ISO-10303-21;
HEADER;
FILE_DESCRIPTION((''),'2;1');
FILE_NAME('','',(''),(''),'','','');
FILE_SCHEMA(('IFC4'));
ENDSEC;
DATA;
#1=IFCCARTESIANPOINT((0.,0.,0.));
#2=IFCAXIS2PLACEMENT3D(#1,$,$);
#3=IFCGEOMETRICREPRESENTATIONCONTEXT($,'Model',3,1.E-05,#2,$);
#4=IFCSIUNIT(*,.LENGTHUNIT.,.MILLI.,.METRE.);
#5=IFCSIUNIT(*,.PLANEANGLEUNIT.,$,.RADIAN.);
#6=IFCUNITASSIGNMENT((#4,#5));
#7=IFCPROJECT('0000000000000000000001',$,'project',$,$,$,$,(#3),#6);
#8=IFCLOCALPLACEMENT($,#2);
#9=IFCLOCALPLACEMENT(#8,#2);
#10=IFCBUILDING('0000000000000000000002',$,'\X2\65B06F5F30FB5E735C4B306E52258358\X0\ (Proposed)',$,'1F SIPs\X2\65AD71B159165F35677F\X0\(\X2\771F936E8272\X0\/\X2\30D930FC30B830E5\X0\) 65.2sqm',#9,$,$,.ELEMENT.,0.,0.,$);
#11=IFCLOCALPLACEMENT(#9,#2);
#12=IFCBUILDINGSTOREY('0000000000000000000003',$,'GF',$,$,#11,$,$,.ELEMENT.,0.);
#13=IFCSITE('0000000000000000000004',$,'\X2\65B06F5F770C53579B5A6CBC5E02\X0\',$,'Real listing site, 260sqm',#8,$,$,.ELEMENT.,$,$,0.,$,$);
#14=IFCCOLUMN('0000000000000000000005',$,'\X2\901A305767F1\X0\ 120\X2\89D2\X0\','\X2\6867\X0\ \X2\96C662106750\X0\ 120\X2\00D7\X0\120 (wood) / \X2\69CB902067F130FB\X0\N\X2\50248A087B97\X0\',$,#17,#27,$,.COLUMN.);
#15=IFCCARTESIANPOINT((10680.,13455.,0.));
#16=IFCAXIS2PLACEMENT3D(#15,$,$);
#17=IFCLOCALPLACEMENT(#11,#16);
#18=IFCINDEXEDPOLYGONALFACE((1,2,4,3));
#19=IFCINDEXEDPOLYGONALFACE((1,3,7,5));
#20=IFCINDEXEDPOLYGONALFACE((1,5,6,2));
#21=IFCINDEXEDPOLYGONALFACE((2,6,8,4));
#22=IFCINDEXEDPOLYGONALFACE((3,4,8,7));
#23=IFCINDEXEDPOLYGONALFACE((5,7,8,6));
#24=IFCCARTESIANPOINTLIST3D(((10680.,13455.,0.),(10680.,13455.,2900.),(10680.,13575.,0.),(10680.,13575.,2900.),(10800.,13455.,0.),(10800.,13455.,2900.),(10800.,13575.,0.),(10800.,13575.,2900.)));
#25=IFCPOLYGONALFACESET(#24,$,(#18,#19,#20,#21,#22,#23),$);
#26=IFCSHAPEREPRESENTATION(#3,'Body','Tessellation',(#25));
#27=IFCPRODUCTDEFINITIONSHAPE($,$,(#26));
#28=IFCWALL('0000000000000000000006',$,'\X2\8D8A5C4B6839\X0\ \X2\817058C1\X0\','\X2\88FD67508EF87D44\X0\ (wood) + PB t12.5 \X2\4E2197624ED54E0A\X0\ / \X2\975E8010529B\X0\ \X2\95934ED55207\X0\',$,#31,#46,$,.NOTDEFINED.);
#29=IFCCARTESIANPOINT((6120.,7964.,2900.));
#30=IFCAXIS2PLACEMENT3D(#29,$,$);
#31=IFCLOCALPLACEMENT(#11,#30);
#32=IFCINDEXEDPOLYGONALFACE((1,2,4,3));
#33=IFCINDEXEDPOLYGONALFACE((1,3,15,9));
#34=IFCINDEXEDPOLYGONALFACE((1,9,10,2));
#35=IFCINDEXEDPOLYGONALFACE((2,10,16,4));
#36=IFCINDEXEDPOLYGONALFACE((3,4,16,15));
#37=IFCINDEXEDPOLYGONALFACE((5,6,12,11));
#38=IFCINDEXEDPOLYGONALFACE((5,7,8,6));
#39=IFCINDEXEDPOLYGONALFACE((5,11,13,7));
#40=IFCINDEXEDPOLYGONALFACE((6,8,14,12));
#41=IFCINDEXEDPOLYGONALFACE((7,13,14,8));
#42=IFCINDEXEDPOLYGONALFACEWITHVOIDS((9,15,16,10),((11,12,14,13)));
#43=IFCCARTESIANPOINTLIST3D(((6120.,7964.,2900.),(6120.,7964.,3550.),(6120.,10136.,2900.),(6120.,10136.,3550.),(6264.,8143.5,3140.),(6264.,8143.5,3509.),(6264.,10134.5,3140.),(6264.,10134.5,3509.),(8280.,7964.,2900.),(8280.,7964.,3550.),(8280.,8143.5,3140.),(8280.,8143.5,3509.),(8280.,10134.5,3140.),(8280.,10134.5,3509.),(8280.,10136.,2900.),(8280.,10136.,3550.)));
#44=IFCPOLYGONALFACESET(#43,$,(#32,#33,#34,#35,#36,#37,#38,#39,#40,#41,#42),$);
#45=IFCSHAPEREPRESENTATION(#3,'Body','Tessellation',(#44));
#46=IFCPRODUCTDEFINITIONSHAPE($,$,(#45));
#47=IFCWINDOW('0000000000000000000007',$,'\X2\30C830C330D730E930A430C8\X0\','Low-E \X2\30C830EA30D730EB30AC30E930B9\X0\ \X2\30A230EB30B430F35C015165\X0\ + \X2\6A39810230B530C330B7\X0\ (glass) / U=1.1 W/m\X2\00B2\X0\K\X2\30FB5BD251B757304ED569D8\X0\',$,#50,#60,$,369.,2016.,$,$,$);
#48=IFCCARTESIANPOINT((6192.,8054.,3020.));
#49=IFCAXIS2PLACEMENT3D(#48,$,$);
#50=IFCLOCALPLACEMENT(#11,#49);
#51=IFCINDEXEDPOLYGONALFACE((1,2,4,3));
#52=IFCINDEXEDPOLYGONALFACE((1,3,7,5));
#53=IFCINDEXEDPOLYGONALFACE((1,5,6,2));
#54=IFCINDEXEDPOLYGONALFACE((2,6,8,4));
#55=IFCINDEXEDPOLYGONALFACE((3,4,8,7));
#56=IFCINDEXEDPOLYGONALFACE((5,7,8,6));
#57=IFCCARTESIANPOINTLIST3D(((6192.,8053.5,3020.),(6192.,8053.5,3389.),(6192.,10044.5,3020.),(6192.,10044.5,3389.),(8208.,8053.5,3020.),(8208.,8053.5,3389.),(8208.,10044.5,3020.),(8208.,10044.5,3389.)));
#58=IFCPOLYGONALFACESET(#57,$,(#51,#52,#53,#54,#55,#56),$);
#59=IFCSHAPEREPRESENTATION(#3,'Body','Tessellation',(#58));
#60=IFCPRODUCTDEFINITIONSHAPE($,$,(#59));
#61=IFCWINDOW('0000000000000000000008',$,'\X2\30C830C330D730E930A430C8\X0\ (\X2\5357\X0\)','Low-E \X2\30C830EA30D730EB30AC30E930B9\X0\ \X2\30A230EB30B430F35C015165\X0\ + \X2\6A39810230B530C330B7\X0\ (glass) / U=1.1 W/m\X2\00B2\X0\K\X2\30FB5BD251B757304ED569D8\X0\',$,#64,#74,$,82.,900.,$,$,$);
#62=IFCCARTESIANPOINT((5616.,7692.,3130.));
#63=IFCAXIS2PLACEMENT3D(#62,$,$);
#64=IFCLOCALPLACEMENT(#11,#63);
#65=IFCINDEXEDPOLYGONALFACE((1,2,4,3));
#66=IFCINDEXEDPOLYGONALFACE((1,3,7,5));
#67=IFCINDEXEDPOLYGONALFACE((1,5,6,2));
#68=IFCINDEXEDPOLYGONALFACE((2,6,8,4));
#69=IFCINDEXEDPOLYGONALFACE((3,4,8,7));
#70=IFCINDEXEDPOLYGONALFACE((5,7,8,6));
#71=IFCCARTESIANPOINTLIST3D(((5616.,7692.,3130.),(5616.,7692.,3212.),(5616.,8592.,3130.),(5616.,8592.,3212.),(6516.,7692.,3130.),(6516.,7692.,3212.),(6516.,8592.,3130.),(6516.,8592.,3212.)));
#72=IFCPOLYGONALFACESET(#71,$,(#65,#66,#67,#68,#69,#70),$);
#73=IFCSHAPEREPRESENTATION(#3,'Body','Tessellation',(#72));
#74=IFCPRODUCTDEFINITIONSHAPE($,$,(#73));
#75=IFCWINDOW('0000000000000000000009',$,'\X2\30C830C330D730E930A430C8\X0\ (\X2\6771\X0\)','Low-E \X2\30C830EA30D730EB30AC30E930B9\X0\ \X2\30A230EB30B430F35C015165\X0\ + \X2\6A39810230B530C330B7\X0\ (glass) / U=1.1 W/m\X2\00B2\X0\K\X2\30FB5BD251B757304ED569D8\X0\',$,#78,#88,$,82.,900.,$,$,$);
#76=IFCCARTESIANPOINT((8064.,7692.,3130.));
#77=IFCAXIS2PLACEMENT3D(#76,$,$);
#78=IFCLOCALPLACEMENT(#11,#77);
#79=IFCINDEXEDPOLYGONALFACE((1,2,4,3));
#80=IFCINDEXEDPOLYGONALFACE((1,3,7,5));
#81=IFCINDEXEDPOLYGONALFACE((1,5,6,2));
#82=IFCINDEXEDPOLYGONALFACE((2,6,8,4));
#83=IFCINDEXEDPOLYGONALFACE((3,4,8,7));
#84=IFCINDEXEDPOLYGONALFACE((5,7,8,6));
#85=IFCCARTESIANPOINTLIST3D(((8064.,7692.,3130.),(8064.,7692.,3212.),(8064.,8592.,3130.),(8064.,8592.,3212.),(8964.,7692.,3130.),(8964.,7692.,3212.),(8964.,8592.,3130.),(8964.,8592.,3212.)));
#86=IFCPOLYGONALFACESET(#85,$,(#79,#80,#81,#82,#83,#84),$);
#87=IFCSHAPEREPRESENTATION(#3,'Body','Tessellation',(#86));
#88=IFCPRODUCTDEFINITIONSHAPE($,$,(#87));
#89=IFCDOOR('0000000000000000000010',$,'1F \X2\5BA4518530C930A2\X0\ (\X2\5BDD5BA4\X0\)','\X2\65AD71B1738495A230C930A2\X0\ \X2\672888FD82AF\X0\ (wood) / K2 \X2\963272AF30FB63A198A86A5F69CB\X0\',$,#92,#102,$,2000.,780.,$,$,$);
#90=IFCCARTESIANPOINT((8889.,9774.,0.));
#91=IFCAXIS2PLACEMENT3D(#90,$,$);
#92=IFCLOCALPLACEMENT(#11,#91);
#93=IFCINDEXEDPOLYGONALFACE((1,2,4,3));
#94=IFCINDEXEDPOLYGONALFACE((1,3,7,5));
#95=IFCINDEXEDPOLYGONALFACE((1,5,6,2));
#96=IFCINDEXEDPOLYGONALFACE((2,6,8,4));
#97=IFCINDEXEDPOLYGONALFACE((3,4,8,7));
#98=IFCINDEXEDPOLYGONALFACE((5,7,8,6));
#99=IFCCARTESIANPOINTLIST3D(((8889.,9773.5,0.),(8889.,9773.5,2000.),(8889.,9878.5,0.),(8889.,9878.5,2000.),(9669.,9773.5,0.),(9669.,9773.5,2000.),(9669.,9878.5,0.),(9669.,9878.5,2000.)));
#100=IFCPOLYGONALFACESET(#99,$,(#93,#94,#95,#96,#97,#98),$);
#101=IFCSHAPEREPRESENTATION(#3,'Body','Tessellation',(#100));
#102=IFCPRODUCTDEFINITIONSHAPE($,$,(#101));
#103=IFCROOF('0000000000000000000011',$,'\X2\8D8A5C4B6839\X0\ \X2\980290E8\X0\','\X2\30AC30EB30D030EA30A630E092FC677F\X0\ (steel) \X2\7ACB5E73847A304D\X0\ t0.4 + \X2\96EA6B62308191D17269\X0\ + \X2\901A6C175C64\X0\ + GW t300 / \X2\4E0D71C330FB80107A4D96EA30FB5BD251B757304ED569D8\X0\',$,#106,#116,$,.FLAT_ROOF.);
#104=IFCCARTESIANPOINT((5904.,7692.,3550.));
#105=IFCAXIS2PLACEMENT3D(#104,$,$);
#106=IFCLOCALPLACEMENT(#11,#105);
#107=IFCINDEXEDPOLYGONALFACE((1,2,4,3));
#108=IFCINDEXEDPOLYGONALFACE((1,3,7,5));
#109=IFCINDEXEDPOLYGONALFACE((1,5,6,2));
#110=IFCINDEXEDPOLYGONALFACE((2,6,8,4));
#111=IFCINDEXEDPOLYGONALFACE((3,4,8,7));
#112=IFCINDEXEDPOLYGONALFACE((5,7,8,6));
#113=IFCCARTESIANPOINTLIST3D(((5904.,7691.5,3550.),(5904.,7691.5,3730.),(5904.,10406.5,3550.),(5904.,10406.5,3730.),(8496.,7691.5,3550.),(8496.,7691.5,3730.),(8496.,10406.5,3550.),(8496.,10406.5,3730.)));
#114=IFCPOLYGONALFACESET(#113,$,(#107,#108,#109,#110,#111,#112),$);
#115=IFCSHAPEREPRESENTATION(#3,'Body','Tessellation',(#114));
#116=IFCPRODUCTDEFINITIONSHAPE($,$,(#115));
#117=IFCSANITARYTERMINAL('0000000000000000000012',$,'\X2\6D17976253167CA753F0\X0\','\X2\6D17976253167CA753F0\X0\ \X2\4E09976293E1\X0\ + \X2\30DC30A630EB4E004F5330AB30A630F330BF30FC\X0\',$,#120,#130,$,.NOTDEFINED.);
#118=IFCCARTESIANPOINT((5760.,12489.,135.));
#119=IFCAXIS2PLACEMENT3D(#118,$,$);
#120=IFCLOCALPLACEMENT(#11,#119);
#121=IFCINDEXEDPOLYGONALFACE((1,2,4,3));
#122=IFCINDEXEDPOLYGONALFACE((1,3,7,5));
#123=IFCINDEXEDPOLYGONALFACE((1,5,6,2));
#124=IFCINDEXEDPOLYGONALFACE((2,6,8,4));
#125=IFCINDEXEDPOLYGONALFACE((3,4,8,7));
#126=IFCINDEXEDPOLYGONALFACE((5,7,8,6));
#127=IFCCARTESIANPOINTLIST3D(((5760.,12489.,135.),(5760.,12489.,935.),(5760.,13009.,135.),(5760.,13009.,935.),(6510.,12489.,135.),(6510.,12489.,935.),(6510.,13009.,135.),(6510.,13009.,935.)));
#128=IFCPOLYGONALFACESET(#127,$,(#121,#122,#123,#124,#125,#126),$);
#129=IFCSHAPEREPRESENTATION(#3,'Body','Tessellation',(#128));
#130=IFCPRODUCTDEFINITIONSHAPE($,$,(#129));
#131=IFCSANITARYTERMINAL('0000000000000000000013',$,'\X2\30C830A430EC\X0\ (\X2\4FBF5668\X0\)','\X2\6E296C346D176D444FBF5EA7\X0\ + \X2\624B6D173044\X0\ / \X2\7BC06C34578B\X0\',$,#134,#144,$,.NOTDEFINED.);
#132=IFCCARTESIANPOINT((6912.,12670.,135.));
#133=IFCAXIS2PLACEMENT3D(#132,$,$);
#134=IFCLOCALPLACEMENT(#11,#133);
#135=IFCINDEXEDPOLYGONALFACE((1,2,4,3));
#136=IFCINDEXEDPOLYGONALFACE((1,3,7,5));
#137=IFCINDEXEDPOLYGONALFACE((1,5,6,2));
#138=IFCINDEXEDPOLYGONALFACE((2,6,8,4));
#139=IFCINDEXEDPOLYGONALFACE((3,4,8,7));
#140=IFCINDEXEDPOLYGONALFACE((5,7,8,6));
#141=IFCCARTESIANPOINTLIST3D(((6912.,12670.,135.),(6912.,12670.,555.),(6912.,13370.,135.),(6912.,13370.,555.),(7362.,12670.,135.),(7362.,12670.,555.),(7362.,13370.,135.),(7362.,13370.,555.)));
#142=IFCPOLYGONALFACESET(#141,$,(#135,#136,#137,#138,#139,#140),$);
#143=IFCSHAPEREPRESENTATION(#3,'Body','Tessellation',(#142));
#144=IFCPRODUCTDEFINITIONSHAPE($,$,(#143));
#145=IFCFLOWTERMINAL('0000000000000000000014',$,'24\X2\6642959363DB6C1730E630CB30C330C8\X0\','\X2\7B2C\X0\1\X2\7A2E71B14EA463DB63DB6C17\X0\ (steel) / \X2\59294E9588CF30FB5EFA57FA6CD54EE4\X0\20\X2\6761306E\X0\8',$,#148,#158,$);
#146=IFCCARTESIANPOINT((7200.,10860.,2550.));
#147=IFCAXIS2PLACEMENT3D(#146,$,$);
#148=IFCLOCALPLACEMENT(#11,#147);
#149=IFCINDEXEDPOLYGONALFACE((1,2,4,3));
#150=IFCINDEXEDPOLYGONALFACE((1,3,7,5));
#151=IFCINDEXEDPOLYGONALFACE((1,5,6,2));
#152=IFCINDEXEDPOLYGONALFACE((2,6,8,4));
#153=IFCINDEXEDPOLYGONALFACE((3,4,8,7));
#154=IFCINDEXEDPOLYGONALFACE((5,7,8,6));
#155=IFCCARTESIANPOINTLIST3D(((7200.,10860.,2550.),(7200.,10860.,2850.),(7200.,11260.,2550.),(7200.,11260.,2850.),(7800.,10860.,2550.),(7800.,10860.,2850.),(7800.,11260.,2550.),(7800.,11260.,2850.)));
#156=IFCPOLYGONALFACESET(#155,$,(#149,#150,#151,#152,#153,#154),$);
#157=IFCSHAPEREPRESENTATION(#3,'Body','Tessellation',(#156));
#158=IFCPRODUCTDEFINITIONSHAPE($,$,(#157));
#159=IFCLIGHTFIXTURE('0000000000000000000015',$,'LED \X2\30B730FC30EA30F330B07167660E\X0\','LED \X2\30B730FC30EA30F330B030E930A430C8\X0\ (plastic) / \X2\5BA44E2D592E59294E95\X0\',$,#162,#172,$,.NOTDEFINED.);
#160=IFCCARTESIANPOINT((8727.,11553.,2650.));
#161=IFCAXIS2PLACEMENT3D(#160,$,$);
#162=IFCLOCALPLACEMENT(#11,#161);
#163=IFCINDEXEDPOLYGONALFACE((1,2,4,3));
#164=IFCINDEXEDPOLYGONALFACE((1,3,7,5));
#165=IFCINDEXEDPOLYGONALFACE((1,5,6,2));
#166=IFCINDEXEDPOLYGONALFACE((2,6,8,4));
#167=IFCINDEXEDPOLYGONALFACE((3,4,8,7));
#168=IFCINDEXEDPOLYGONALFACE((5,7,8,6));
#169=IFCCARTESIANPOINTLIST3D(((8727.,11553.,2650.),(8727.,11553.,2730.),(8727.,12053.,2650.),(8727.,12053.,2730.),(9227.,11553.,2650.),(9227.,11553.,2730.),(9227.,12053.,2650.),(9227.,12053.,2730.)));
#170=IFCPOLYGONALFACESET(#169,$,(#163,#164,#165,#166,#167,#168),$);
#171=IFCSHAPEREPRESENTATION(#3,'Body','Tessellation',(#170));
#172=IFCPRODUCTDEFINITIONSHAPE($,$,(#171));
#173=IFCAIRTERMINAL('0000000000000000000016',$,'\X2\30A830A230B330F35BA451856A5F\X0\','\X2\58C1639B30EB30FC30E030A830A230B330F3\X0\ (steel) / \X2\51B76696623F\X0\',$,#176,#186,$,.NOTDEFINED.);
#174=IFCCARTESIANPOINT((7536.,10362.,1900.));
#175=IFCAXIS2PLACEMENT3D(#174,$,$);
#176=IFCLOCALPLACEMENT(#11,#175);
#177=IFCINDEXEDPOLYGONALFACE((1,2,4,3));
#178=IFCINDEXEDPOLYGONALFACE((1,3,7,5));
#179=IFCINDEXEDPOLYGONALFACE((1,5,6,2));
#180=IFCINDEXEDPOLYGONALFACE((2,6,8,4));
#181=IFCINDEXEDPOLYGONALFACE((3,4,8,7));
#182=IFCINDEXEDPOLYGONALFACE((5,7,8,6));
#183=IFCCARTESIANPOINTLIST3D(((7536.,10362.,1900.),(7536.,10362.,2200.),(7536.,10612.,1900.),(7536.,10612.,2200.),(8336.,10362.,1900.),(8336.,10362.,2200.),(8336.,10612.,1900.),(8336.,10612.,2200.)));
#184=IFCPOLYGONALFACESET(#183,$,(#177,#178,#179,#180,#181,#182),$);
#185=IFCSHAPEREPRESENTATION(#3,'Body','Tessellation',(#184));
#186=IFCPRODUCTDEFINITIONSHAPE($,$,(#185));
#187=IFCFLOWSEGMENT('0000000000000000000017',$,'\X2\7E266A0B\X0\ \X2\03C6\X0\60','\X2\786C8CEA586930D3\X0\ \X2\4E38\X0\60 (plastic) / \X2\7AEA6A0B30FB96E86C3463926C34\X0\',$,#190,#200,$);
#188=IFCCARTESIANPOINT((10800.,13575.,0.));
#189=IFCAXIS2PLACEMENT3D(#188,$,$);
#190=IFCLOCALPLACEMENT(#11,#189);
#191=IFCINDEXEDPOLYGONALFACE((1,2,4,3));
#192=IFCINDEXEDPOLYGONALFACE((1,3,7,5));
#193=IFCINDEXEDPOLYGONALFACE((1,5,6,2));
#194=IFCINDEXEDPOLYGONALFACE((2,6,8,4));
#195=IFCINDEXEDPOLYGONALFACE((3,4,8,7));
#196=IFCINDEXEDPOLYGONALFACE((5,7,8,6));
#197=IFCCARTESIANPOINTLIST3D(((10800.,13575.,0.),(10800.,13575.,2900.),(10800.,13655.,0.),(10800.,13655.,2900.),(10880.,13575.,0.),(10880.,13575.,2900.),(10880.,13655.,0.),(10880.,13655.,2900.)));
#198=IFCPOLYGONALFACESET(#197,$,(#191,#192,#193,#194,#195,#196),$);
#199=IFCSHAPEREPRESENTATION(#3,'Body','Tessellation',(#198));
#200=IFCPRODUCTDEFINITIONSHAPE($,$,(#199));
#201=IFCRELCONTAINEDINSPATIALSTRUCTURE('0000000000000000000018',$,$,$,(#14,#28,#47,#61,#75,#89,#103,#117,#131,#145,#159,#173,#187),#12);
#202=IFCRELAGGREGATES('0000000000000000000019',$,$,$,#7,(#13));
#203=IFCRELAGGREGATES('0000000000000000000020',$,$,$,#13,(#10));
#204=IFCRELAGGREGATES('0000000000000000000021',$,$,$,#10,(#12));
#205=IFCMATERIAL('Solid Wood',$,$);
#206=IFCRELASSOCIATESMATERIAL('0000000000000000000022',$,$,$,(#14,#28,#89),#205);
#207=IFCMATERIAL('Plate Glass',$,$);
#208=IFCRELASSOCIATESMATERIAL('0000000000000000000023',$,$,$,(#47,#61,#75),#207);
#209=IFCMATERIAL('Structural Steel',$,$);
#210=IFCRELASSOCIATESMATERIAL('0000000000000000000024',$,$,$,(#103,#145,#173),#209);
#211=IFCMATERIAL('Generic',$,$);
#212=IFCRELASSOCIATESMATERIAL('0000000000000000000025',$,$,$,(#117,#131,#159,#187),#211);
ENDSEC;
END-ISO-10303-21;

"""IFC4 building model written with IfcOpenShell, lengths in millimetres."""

from ifc_helpers import new_model, si_unit, frame, frame_2d, origin, place, context, project, spatial, rectangle, extrude, material, element, fill, save


model = new_model("IFC4")

# Units and contexts
model_context = context("Model", 3, precision=1e-05, world=origin())
ifc_project = project(units=[si_unit("LENGTHUNIT", "METRE", prefix="MILLI"), si_unit("PLANEANGLEUNIT", "RADIAN")], contexts=[model_context])

# Site, building, storey
site_placement = place(None, origin())
site = spatial("IfcSite", under=ifc_project, at=site_placement, Name="新潟県南魚沼市", ObjectType="Real listing site, 260sqm", CompositionType="ELEMENT", RefElevation=0.0)
building_placement = place(site_placement, origin())
building = spatial("IfcBuilding", under=site, at=building_placement, Name="新潟・平屋の別荘 (Proposed)", ObjectType="1F SIPs断熱外張板(真鍮色/ベージュ) 65.2sqm", CompositionType="ELEMENT", ElevationOfRefHeight=0.0, ElevationOfTerrain=0.0)
storey_placement = place(building_placement, origin())
storey = spatial("IfcBuildingStorey", under=building, at=storey_placement, Name="GF", CompositionType="ELEMENT", Elevation=0.0)

# Column
ifc_material_1 = material(Name="Solid Wood")
column_1_placement = place(storey_placement, frame((10680.0, 13455.0, 0.0)))
element("IfcColumn", 1, at=column_1_placement, inside=storey, material=ifc_material_1, Name="通し柱 120角", Description="桧 集成材 120×120 (wood) / 構造柱・N値計算", PredefinedType="COLUMN", context=model_context, shape_type="SweptSolid", body=[
    extrude(rectangle(XDim=120.0, YDim=120.0, at=frame_2d((60.0, 60.0))), frame((10680.0, 13455.0, 0.0)), (0.0, 0.0, 1.0), 2900.0),
])

# Wall, openings, windows
wall_1_placement = place(storey_placement, frame((6120.0, 7964.0, 2900.0)))
wall_1 = element("IfcWall", 2, at=wall_1_placement, inside=storey, material=ifc_material_1, Name="越屋根 腰壁", Description="製材軸組 (wood) + PB t12.5 両面仕上 / 非耐力 間仕切", PredefinedType="NOTDEFINED", context=model_context, shape_type="SweptSolid", body=[
    extrude(rectangle(XDim=2160.0, YDim=2172.0, at=frame_2d((1080.0, 1086.0))), frame((6120.0, 7964.0, 2900.0)), (0.0, 0.0, 1.0), 650.0),
])
opening_1_placement = place(storey_placement, frame((6192.0, 8054.0, 3020.0)))
opening_1 = element("IfcOpeningElement", 3, at=opening_1_placement, cuts=wall_1, PredefinedType="NOTDEFINED", context=model_context, shape_type="SweptSolid", body=[
    extrude(rectangle(XDim=2016.0, YDim=1991.0, at=frame_2d((1008.0, 995.0))), frame((6192.0, 8054.0, 3020.0)), (0.0, 0.0, 1.0), 369.0),
])
opening_2_placement = place(storey_placement, frame((5616.0, 7692.0, 3130.0)))
opening_2 = element("IfcOpeningElement", 4, at=opening_2_placement, cuts=wall_1, PredefinedType="NOTDEFINED", context=model_context, shape_type="SweptSolid", body=[
    extrude(rectangle(XDim=900.0, YDim=900.0, at=frame_2d((450.0, 450.0))), frame((5616.0, 7692.0, 3130.0)), (0.0, 0.0, 1.0), 82.0),
])
opening_3_placement = place(storey_placement, frame((8064.0, 7692.0, 3130.0)))
opening_3 = element("IfcOpeningElement", 5, at=opening_3_placement, cuts=wall_1, PredefinedType="NOTDEFINED", context=model_context, shape_type="SweptSolid", body=[
    extrude(rectangle(XDim=900.0, YDim=900.0, at=frame_2d((450.0, 450.0))), frame((8064.0, 7692.0, 3130.0)), (0.0, 0.0, 1.0), 82.0),
])
ifc_material_2 = material(Name="Plate Glass")
window_1_placement = place(storey_placement, frame((6192.0, 8054.0, 3020.0)))
window_1 = element("IfcWindow", 6, at=window_1_placement, inside=storey, material=ifc_material_2, Name="トップライト", Description="Low-E トリプルガラス アルゴン封入 + 樹脂サッシ (glass) / U=1.1 W/m²K・寒冷地仕様", OverallHeight=369.0, OverallWidth=2016.0, context=model_context, shape_type="SweptSolid", body=[
    extrude(rectangle(XDim=2016.0, YDim=1991.0, at=frame_2d((1008.0, 995.0))), frame((6192.0, 8054.0, 3020.0)), (0.0, 0.0, 1.0), 369.0),
])
fill(opening_1, window_1)
window_2_placement = place(storey_placement, frame((5616.0, 7692.0, 3130.0)))
window_2 = element("IfcWindow", 7, at=window_2_placement, inside=storey, material=ifc_material_2, Name="トップライト (南)", Description="Low-E トリプルガラス アルゴン封入 + 樹脂サッシ (glass) / U=1.1 W/m²K・寒冷地仕様", OverallHeight=82.0, OverallWidth=900.0, context=model_context, shape_type="SweptSolid", body=[
    extrude(rectangle(XDim=900.0, YDim=900.0, at=frame_2d((450.0, 450.0))), frame((5616.0, 7692.0, 3130.0)), (0.0, 0.0, 1.0), 82.0),
])
fill(opening_2, window_2)
window_3_placement = place(storey_placement, frame((8064.0, 7692.0, 3130.0)))
window_3 = element("IfcWindow", 8, at=window_3_placement, inside=storey, material=ifc_material_2, Name="トップライト (東)", Description="Low-E トリプルガラス アルゴン封入 + 樹脂サッシ (glass) / U=1.1 W/m²K・寒冷地仕様", OverallHeight=82.0, OverallWidth=900.0, context=model_context, shape_type="SweptSolid", body=[
    extrude(rectangle(XDim=900.0, YDim=900.0, at=frame_2d((450.0, 450.0))), frame((8064.0, 7692.0, 3130.0)), (0.0, 0.0, 1.0), 82.0),
])
fill(opening_3, window_3)

# Door
door_placement = place(storey_placement, frame((8889.0, 9774.0, 0.0)))
element("IfcDoor", 9, at=door_placement, inside=storey, material=ifc_material_1, Name="1F 室内ドア (寝室)", Description="断熱玄関ドア 木製芯 (wood) / K2 防犯・採風機構", OverallHeight=2000.0, OverallWidth=780.0, context=model_context, shape_type="SweptSolid", body=[
    extrude(rectangle(XDim=780.0, YDim=105.0, at=frame_2d((390.0, 52.0))), frame((8889.0, 9774.0, 0.0)), (0.0, 0.0, 1.0), 2000.0),
])

# Roof
ifc_material_3 = material(Name="Structural Steel")
roof_placement = place(storey_placement, frame((5904.0, 7692.0, 3550.0)))
element("IfcRoof", 10, at=roof_placement, inside=storey, material=ifc_material_3, Name="越屋根 頂部", Description="ガルバリウム鋼板 (steel) 立平葺き t0.4 + 雪止め金物 + 通気層 + GW t300 / 不燃・耐積雪・寒冷地仕様", PredefinedType="FLAT_ROOF", context=model_context, shape_type="SweptSolid", body=[
    extrude(rectangle(XDim=2592.0, YDim=2715.0, at=frame_2d((1296.0, 1357.0))), frame((5904.0, 7692.0, 3550.0)), (0.0, 0.0, 1.0), 180.0),
])

# Sanitary terminals
ifc_material_4 = material(Name="Generic")
sanitary_terminal_1_placement = place(storey_placement, frame((5760.0, 12489.0, 135.0)))
element("IfcSanitaryTerminal", 11, at=sanitary_terminal_1_placement, inside=storey, material=ifc_material_4, Name="洗面化粧台", Description="洗面化粧台 三面鏡 + ボウル一体カウンター", PredefinedType="NOTDEFINED", context=model_context, shape_type="SweptSolid", body=[
    extrude(rectangle(XDim=750.0, YDim=520.0, at=frame_2d((375.0, 260.0))), frame((5760.0, 12489.0, 135.0)), (0.0, 0.0, 1.0), 800.0),
])
sanitary_terminal_2_placement = place(storey_placement, frame((6912.0, 12670.0, 135.0)))
element("IfcSanitaryTerminal", 12, at=sanitary_terminal_2_placement, inside=storey, material=ifc_material_4, Name="トイレ (便器)", Description="温水洗浄便座 + 手洗い / 節水型", PredefinedType="NOTDEFINED", context=model_context, shape_type="SweptSolid", body=[
    extrude(rectangle(XDim=450.0, YDim=700.0, at=frame_2d((225.0, 350.0))), frame((6912.0, 12670.0, 135.0)), (0.0, 0.0, 1.0), 420.0),
])

# Flow terminal
flow_terminal_placement = place(storey_placement, frame((7200.0, 10860.0, 2550.0)))
element("IfcFlowTerminal", 13, at=flow_terminal_placement, inside=storey, material=ifc_material_3, Name="24時間換気ユニット", Description="第1種熱交換換気 (steel) / 天井裏・建基法令20条の8", context=model_context, shape_type="SweptSolid", body=[
    extrude(rectangle(XDim=600.0, YDim=400.0, at=frame_2d((300.0, 200.0))), frame((7200.0, 10860.0, 2550.0)), (0.0, 0.0, 1.0), 300.0),
])

# Light fixture
light_fixture_placement = place(storey_placement, frame((8727.0, 11553.0, 2650.0)))
element("IfcLightFixture", 14, at=light_fixture_placement, inside=storey, material=ifc_material_4, Name="LED シーリング照明", Description="LED シーリングライト (plastic) / 室中央天井", PredefinedType="NOTDEFINED", context=model_context, shape_type="SweptSolid", body=[
    extrude(rectangle(XDim=500.0, YDim=500.0, at=frame_2d((250.0, 250.0))), frame((8727.0, 11553.0, 2650.0)), (0.0, 0.0, 1.0), 80.0),
])

# Air terminal
air_terminal_placement = place(storey_placement, frame((7536.0, 10362.0, 1900.0)))
element("IfcAirTerminal", 15, at=air_terminal_placement, inside=storey, material=ifc_material_3, Name="エアコン室内機", Description="壁掛ルームエアコン (steel) / 冷暖房", PredefinedType="NOTDEFINED", context=model_context, shape_type="SweptSolid", body=[
    extrude(rectangle(XDim=800.0, YDim=250.0, at=frame_2d((400.0, 125.0))), frame((7536.0, 10362.0, 1900.0)), (0.0, 0.0, 1.0), 300.0),
])

# Flow segment
flow_segment_placement = place(storey_placement, frame((10800.0, 13575.0, 0.0)))
element("IfcFlowSegment", 16, at=flow_segment_placement, inside=storey, material=ifc_material_4, Name="縦樋 φ60", Description="硬質塩ビ 丸60 (plastic) / 竪樋・雨水排水", context=model_context, shape_type="SweptSolid", body=[
    extrude(rectangle(XDim=80.0, YDim=80.0, at=frame_2d((40.0, 40.0))), frame((10800.0, 13575.0, 0.0)), (0.0, 0.0, 1.0), 2900.0),
])

save(model, "model.ifc")
